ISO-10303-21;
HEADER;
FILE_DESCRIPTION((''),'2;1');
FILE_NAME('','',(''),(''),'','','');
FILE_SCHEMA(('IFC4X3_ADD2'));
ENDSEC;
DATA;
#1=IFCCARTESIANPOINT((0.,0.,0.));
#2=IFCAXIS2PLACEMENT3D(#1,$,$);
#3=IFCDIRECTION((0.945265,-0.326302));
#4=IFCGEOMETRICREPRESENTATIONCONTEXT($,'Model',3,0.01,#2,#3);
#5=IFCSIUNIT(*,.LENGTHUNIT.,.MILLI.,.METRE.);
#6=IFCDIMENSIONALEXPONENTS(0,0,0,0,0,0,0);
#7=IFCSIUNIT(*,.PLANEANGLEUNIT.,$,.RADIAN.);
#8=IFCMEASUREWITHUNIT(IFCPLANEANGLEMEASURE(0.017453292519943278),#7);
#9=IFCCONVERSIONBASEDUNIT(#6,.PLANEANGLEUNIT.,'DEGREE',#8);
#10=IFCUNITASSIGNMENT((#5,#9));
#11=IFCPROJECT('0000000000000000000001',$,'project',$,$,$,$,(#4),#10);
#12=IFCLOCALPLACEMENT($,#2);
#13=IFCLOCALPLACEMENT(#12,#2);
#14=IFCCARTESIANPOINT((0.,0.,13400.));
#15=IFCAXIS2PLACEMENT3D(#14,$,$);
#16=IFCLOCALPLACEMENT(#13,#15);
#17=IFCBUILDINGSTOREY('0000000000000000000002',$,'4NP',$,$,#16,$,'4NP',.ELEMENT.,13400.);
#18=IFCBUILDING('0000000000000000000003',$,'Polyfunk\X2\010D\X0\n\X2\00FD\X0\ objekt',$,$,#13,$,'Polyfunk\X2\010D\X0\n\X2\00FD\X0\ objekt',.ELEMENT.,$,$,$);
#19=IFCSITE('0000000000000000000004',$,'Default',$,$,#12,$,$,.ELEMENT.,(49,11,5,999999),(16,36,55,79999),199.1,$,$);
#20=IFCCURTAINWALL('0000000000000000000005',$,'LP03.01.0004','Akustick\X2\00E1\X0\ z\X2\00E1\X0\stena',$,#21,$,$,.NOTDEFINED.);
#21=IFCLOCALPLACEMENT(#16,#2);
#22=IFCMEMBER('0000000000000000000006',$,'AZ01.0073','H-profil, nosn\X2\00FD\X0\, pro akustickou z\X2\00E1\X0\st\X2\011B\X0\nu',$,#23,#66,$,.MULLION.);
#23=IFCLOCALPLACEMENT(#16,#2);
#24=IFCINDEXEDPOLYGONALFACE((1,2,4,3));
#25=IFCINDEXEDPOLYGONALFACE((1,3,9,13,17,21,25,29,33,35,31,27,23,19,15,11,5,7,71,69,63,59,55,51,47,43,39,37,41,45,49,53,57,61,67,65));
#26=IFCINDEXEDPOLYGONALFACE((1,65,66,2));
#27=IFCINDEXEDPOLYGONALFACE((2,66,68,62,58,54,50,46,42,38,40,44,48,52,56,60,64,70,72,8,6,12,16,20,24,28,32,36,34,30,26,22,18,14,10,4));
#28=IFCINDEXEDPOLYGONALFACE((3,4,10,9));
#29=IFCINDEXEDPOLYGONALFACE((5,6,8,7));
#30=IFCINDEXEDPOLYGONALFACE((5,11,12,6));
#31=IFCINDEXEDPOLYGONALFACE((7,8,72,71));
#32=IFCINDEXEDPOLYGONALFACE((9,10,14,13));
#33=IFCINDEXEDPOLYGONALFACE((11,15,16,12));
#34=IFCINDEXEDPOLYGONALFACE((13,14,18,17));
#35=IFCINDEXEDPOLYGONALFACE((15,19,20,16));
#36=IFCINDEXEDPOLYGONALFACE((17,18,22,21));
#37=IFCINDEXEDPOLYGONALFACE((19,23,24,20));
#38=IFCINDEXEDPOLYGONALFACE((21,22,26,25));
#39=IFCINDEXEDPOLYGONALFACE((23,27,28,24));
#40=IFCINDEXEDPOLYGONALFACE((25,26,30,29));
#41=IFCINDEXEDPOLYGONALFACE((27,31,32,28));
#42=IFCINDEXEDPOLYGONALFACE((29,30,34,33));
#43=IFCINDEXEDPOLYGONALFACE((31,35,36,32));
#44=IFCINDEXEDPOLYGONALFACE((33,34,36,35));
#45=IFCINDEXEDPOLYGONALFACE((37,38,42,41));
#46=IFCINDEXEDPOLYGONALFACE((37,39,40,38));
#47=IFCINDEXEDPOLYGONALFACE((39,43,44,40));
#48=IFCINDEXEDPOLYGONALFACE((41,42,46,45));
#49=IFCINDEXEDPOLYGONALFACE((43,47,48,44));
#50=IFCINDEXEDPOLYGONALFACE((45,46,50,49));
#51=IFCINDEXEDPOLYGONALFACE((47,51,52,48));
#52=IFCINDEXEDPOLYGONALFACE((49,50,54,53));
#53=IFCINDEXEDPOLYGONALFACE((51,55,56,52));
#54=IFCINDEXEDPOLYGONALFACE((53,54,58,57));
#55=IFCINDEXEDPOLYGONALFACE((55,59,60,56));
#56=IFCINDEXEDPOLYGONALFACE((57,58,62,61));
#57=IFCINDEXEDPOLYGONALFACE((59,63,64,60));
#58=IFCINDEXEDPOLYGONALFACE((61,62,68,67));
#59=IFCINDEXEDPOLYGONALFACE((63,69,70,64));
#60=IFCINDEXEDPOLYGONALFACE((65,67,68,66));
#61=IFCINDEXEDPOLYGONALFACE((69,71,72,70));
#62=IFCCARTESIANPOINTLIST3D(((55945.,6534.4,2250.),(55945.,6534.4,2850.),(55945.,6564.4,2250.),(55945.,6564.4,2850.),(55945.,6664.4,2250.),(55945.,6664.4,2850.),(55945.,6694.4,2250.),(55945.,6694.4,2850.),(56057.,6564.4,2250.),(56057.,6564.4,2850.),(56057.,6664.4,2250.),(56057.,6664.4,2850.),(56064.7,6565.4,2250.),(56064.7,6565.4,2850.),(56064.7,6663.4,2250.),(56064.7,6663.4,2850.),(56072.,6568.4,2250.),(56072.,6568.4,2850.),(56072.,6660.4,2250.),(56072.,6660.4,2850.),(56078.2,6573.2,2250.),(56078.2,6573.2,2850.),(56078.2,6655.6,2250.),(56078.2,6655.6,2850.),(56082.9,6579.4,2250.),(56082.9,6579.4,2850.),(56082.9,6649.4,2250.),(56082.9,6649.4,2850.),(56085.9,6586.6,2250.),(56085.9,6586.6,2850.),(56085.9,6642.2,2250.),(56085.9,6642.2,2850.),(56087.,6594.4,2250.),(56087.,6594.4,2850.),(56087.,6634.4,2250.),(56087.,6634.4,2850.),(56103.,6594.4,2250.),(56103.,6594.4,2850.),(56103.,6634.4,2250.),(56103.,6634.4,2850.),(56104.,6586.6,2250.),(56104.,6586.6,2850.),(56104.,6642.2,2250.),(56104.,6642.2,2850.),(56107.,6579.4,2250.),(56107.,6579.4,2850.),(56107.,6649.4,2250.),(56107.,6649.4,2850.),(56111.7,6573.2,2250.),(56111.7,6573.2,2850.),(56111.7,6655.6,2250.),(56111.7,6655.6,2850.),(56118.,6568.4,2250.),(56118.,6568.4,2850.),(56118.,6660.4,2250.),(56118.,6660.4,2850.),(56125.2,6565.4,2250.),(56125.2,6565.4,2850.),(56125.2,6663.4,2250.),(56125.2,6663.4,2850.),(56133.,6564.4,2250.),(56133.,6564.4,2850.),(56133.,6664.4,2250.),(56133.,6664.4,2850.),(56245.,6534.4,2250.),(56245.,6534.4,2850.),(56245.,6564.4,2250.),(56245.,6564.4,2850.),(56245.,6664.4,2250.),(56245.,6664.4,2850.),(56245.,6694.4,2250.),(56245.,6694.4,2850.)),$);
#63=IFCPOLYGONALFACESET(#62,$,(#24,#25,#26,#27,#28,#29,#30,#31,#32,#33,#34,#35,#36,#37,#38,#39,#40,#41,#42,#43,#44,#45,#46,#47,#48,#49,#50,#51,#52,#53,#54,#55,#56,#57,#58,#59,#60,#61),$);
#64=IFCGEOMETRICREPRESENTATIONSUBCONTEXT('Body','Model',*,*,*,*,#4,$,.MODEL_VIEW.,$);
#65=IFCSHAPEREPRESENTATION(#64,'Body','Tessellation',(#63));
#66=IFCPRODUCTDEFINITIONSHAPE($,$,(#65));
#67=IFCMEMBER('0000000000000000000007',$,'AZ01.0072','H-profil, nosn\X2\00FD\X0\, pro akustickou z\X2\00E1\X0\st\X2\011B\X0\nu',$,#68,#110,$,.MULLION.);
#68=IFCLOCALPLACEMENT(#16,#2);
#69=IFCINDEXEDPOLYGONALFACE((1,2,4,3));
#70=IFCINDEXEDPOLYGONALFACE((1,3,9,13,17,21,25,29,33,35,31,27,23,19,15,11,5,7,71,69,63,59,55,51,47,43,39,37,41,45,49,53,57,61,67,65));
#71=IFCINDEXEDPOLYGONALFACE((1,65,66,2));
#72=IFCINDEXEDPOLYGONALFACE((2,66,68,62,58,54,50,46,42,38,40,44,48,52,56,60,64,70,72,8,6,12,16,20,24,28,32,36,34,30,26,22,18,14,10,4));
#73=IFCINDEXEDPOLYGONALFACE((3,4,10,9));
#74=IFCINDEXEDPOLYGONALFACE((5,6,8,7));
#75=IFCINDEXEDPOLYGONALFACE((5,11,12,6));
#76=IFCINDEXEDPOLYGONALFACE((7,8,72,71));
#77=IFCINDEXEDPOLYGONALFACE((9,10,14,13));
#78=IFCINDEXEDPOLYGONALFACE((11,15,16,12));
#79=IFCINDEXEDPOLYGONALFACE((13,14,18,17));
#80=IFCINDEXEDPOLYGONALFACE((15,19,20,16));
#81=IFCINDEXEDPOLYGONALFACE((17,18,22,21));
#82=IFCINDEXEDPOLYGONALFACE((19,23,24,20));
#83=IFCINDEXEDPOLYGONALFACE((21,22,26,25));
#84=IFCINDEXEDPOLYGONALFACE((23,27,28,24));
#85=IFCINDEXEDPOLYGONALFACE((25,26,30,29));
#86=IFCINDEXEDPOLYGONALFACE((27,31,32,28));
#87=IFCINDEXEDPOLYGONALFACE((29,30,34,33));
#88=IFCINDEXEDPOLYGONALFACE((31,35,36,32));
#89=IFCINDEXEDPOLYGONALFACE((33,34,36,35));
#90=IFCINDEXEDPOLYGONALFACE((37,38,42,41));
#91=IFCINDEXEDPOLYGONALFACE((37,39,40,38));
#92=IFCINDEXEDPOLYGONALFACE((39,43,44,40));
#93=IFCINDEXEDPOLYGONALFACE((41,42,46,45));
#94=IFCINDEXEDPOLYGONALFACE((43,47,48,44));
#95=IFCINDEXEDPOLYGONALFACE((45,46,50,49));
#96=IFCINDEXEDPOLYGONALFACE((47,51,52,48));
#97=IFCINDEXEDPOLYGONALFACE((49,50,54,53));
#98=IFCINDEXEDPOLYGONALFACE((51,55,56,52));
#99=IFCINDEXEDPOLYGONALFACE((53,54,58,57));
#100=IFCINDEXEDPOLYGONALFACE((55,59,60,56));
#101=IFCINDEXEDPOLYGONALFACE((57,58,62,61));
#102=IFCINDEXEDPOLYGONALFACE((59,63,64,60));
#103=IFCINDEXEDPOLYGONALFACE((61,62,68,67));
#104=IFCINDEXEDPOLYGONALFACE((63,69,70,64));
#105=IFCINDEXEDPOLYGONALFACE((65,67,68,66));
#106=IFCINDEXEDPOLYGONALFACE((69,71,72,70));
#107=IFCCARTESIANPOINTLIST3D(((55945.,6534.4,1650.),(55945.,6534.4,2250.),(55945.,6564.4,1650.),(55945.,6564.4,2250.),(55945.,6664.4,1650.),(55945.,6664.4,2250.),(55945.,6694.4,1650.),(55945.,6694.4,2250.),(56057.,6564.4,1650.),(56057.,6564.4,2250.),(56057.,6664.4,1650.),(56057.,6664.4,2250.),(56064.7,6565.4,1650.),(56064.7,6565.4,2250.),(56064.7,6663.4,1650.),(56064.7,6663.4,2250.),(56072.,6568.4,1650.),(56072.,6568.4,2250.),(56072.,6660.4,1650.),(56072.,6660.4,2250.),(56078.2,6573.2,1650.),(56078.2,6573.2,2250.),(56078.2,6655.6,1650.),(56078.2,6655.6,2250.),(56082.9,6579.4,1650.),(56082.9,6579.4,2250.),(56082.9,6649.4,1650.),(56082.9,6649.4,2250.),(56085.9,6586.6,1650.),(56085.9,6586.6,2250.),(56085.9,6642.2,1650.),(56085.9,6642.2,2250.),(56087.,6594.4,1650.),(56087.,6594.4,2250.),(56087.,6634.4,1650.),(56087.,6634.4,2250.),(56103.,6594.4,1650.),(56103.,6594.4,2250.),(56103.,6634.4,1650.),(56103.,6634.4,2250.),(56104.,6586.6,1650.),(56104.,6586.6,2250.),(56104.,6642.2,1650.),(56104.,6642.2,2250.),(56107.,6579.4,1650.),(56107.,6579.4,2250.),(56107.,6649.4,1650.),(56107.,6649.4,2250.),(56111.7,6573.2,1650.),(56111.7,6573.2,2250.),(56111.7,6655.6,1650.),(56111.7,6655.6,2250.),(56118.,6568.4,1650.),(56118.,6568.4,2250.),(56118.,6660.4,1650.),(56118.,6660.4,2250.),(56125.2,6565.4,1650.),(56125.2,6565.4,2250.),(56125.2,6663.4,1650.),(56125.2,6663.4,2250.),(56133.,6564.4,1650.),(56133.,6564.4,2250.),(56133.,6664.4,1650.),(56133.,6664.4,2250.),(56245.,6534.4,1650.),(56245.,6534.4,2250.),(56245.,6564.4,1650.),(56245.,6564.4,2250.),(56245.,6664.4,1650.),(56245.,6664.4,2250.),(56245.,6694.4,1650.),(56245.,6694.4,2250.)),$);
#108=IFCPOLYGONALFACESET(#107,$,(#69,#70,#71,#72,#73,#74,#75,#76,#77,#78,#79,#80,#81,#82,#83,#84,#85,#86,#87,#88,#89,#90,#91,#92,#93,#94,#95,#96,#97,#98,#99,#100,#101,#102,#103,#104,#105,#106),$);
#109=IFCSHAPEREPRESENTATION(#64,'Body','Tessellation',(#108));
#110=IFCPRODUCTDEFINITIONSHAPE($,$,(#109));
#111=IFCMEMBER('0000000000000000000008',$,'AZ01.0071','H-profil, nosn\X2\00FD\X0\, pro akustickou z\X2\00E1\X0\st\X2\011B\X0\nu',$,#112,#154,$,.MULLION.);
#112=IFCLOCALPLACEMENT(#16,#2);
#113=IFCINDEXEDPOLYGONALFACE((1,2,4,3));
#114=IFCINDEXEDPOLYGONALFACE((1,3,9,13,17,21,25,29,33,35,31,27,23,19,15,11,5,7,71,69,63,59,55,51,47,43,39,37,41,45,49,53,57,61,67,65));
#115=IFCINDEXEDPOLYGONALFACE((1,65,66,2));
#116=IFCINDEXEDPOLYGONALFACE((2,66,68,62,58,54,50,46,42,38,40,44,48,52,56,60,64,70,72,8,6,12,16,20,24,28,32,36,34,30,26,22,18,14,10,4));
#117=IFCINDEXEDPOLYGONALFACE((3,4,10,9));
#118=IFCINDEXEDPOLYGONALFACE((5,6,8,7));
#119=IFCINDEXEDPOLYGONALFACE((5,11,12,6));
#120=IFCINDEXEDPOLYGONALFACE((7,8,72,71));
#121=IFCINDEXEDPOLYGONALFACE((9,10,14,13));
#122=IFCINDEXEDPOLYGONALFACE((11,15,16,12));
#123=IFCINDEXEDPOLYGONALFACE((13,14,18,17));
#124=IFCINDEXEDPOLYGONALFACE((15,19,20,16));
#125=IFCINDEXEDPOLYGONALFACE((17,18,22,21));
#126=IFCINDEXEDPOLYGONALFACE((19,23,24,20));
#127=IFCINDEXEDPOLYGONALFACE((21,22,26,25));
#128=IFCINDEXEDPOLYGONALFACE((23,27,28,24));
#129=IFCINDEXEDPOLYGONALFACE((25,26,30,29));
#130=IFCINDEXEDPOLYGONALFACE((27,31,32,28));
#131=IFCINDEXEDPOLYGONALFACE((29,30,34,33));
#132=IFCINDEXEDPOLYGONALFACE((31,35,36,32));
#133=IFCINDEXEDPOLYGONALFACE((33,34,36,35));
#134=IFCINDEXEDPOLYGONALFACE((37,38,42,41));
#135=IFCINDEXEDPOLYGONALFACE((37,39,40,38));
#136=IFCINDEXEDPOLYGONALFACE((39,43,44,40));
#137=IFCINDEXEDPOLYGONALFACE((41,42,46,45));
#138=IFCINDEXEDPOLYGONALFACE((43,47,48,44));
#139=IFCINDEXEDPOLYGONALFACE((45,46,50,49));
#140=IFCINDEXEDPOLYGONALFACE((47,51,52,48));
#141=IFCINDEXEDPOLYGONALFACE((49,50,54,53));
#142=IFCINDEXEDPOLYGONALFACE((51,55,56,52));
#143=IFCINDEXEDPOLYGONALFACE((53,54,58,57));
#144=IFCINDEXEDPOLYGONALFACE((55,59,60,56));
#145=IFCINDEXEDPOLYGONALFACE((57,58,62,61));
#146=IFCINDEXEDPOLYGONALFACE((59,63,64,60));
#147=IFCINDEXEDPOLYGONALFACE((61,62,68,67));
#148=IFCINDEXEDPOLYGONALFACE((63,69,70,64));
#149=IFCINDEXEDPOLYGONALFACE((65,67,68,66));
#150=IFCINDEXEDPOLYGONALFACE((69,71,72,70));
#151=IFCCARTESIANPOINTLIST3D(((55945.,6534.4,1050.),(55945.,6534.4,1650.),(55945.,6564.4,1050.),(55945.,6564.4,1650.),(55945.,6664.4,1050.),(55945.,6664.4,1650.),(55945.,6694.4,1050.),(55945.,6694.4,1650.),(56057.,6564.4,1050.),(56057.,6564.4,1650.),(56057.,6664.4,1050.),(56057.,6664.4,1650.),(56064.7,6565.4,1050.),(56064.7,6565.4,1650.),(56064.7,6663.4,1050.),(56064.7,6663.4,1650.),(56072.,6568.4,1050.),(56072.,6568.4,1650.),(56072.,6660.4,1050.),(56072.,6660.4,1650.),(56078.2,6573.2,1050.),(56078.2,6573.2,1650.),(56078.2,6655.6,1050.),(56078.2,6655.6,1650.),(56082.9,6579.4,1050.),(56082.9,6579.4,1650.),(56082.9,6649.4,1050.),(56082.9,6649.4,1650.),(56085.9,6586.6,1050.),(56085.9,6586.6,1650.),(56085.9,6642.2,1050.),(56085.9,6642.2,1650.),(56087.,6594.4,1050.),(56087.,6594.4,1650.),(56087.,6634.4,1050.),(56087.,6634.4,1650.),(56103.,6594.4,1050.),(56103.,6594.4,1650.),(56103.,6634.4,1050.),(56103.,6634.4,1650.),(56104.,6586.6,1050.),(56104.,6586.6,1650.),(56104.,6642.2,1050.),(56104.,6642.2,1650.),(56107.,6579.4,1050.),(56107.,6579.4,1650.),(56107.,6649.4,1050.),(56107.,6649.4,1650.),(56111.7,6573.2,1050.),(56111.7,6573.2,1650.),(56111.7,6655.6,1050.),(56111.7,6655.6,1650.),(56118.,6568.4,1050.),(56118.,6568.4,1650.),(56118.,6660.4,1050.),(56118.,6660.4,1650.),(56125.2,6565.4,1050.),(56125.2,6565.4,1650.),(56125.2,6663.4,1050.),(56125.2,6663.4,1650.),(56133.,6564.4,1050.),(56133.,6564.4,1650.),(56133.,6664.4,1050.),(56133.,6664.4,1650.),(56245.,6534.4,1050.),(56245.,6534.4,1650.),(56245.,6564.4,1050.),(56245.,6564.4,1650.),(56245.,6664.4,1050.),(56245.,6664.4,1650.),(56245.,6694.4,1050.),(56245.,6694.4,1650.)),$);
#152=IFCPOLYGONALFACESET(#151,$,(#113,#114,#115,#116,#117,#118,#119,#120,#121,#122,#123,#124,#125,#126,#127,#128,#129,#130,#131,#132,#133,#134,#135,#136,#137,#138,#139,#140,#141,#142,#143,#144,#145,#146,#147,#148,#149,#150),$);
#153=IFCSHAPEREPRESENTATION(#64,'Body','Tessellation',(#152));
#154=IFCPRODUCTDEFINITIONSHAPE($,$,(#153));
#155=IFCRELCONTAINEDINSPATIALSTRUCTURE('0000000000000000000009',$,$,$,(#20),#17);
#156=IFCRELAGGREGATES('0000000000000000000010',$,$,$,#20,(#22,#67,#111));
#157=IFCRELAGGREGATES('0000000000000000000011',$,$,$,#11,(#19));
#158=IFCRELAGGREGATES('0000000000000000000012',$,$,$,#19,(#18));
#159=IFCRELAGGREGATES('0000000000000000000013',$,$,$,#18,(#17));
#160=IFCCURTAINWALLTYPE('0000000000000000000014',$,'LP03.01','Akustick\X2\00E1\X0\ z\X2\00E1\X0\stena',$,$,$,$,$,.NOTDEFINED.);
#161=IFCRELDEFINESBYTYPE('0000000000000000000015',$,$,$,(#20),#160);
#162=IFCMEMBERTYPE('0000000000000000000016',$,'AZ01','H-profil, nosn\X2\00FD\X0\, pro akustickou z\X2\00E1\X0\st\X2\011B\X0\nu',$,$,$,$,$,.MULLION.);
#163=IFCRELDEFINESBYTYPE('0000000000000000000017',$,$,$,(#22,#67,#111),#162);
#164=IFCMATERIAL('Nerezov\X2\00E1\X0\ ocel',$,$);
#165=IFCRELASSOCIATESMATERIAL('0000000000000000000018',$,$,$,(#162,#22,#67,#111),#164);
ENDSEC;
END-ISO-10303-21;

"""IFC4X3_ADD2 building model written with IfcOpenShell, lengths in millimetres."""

from ifc_helpers import new_model, entity, si_unit, converted_unit, direction, frame, frame_2d, origin, place, context, subcontext, project, spatial, polyline, circle_curve, parameter, trimmed, segment, composite_curve, outline, extrude, source, transform, mapped, material, material_profile, profile_set, profile_usage, type_object, element, aggregate, save


model = new_model("IFC4X3_ADD2")

# Units and contexts
model_context = context("Model", 3, precision=0.01, world=origin(), true_north=direction((0.945265, -0.326302)))
body_context = subcontext(model_context, "Body", "Model", "MODEL_VIEW")
ifc_project = project(units=[si_unit("LENGTHUNIT", "METRE", prefix="MILLI"), converted_unit("PLANEANGLEUNIT", "DEGREE", entity("IfcPlaneAngleMeasure", 0.017453292519943278), si_unit("PLANEANGLEUNIT", "RADIAN"), dimensions=[0, 0, 0, 0, 0, 0, 0])], contexts=[model_context])

# Site, building, storey
site_placement = place(None, origin())
site = spatial("IfcSite", under=ifc_project, at=site_placement, Name="Default", CompositionType="ELEMENT", RefLatitude=(49, 11, 5, 999999), RefLongitude=(16, 36, 55, 79999), RefElevation=199.1)
building_placement = place(site_placement, origin())
building = spatial("IfcBuilding", under=site, at=building_placement, Name="Polyfunkčný objekt", LongName="Polyfunkčný objekt", CompositionType="ELEMENT")
storey_placement = place(building_placement, frame((0.0, 0.0, 13400.0)))
storey = spatial("IfcBuildingStorey", under=building, at=storey_placement, Name="4NP", LongName="4NP", CompositionType="ELEMENT", Elevation=13400.0)

# Curtain wall, members
curtain_wall_type = type_object("IfcCurtainWallType", Name="LP03.01", Description="Akustická zástena", PredefinedType="NOTDEFINED")
curtain_wall_placement = place(storey_placement, frame((0.0, 0.0, -13400.0)))
curtain_wall = element("IfcCurtainWall", 1, at=curtain_wall_placement, inside=storey, type_object=curtain_wall_type, Name="LP03.01.0004", Description="Akustická zástena", PredefinedType="NOTDEFINED")
ifc_material_1 = material(Name="Nerezová ocel")
ifc_material_profile = material_profile(ifc_material_1, outline(composite_curve([segment(polyline([(50.0, -150.0), (80.0, -150.0)]), True, "CONTINUOUS"), segment(polyline([(80.0, -150.0), (80.0, 150.0)]), True, "CONTINUOUS"), segment(polyline([(80.0, 150.0), (50.0, 150.0)]), True, "CONTINUOUS"), segment(polyline([(50.0, 150.0), (50.0, 38.0)]), True, "CONTINUOUS"), segment(trimmed(circle_curve(frame_2d((20.0, 38.0), x_axis=(0.0, 1.0)), 30.0), [parameter(180.0)], [parameter(270.0)], True, "PARAMETER"), False, "CONTINUOUS"), segment(polyline([(20.0, 8.0), (-20.0, 8.0)]), True, "CONTINUOUS"), segment(trimmed(circle_curve(frame_2d((-20.0, 38.0), x_axis=(0.0, 1.0)), 30.0), [parameter(90.0)], [parameter(180.0)], True, "PARAMETER"), False, "CONTINUOUS"), segment(polyline([(-50.0, 38.0), (-50.0, 150.0)]), True, "CONTINUOUS"), segment(polyline([(-50.0, 150.0), (-80.0, 150.0)]), True, "CONTINUOUS"), segment(polyline([(-80.0, 150.0), (-80.0, -150.0)]), True, "CONTINUOUS"), segment(polyline([(-80.0, -150.0), (-50.0, -150.0)]), True, "CONTINUOUS"), segment(polyline([(-50.0, -150.0), (-50.0, -38.0)]), True, "CONTINUOUS"), segment(trimmed(circle_curve(frame_2d((-20.0, -38.0), x_axis=(0.0, 1.0)), 30.0), [parameter(0.0)], [parameter(90.0)], True, "PARAMETER"), False, "CONTINUOUS"), segment(polyline([(-20.0, -8.0), (20.0, -8.0)]), True, "CONTINUOUS"), segment(trimmed(circle_curve(frame_2d((20.0, -38.0), x_axis=(0.0, 1.0)), 30.0), [parameter(270.0)], [parameter(0.0)], True, "PARAMETER"), False, "CONTINUOUS"), segment(polyline([(50.0, -38.0), (50.0, -150.0)]), True, "CONTINUOUS")], self_intersect=False)), Name="Profil zástena")
ifc_profile_set = profile_set([ifc_material_profile], Name="Profil zástena")
ifc_profile_usage = profile_usage(ifc_profile_set)
member_type = type_object("IfcMemberType", Name="AZ01", Description="H-profil, nosný, pro akustickou zástěnu", PredefinedType="MULLION", material=ifc_profile_set)
shared_shape_1 = source(origin(), body_context, "Body", "SweptSolid", [
    extrude(outline(composite_curve([segment(polyline([(50.0, -150.0), (80.0, -150.0)]), True, "CONTINUOUS"), segment(polyline([(80.0, -150.0), (80.0, 150.0)]), True, "CONTINUOUS"), segment(polyline([(80.0, 150.0), (50.0, 150.0)]), True, "CONTINUOUS"), segment(polyline([(50.0, 150.0), (50.0, 38.0)]), True, "CONTINUOUS"), segment(trimmed(circle_curve(frame_2d((20.0, 38.0), x_axis=(0.0, 1.0)), 30.0), [parameter(180.0)], [parameter(270.0)], True, "PARAMETER"), False, "CONTINUOUS"), segment(polyline([(20.0, 8.0), (-20.0, 8.0)]), True, "CONTINUOUS"), segment(trimmed(circle_curve(frame_2d((-20.0, 38.0), x_axis=(0.0, 1.0)), 30.0), [parameter(90.0)], [parameter(180.0)], True, "PARAMETER"), False, "CONTINUOUS"), segment(polyline([(-50.0, 38.0), (-50.0, 150.0)]), True, "CONTINUOUS"), segment(polyline([(-50.0, 150.0), (-80.0, 150.0)]), True, "CONTINUOUS"), segment(polyline([(-80.0, 150.0), (-80.0, -150.0)]), True, "CONTINUOUS"), segment(polyline([(-80.0, -150.0), (-50.0, -150.0)]), True, "CONTINUOUS"), segment(polyline([(-50.0, -150.0), (-50.0, -38.0)]), True, "CONTINUOUS"), segment(trimmed(circle_curve(frame_2d((-20.0, -38.0), x_axis=(0.0, 1.0)), 30.0), [parameter(0.0)], [parameter(90.0)], True, "PARAMETER"), False, "CONTINUOUS"), segment(polyline([(-20.0, -8.0), (20.0, -8.0)]), True, "CONTINUOUS"), segment(trimmed(circle_curve(frame_2d((20.0, -38.0), x_axis=(0.0, 1.0)), 30.0), [parameter(270.0)], [parameter(0.0)], True, "PARAMETER"), False, "CONTINUOUS"), segment(polyline([(50.0, -38.0), (50.0, -150.0)]), True, "CONTINUOUS")], self_intersect=False)), frame((-150.0, 0.0, -600.0), z_axis=(0.0, 0.0, 1.0), x_axis=(0.0, -1.0, 0.0)), (0.0, 0.0, 1.0), 600.0),
])
member_1_placement = place(curtain_wall_placement, frame((56245.0, 6614.4, 15650.0), z_axis=(0.0, 0.0, -1.0), x_axis=(1.0, 0.0, 0.0)))
member_1 = element("IfcMember", 2, at=member_1_placement, type_object=member_type, material=ifc_profile_usage, Name="AZ01.0073", Description="H-profil, nosný, pro akustickou zástěnu", PredefinedType="MULLION", context=body_context, shape_type="MappedRepresentation", body=[
    mapped(shared_shape_1, transform((0.0, 0.0, 0.0), scale=1.0)),
])
member_2_placement = place(curtain_wall_placement, frame((56245.0, 6614.4, 15050.0), z_axis=(0.0, 0.0, -1.0), x_axis=(1.0, 0.0, 0.0)))
member_2 = element("IfcMember", 3, at=member_2_placement, type_object=member_type, material=ifc_profile_usage, Name="AZ01.0072", Description="H-profil, nosný, pro akustickou zástěnu", PredefinedType="MULLION", context=body_context, shape_type="MappedRepresentation", body=[
    mapped(shared_shape_1, transform((0.0, 0.0, 0.0), scale=1.0)),
])
member_3_placement = place(curtain_wall_placement, frame((56245.0, 6614.4, 14450.0), z_axis=(0.0, 0.0, -1.0), x_axis=(1.0, 0.0, 0.0)))
member_3 = element("IfcMember", 4, at=member_3_placement, type_object=member_type, material=ifc_profile_usage, Name="AZ01.0071", Description="H-profil, nosný, pro akustickou zástěnu", PredefinedType="MULLION", context=body_context, shape_type="MappedRepresentation", body=[
    mapped(shared_shape_1, transform((0.0, 0.0, 0.0), scale=1.0)),
])
aggregate(curtain_wall, [member_1, member_2, member_3])

save(model, "model.ifc")
